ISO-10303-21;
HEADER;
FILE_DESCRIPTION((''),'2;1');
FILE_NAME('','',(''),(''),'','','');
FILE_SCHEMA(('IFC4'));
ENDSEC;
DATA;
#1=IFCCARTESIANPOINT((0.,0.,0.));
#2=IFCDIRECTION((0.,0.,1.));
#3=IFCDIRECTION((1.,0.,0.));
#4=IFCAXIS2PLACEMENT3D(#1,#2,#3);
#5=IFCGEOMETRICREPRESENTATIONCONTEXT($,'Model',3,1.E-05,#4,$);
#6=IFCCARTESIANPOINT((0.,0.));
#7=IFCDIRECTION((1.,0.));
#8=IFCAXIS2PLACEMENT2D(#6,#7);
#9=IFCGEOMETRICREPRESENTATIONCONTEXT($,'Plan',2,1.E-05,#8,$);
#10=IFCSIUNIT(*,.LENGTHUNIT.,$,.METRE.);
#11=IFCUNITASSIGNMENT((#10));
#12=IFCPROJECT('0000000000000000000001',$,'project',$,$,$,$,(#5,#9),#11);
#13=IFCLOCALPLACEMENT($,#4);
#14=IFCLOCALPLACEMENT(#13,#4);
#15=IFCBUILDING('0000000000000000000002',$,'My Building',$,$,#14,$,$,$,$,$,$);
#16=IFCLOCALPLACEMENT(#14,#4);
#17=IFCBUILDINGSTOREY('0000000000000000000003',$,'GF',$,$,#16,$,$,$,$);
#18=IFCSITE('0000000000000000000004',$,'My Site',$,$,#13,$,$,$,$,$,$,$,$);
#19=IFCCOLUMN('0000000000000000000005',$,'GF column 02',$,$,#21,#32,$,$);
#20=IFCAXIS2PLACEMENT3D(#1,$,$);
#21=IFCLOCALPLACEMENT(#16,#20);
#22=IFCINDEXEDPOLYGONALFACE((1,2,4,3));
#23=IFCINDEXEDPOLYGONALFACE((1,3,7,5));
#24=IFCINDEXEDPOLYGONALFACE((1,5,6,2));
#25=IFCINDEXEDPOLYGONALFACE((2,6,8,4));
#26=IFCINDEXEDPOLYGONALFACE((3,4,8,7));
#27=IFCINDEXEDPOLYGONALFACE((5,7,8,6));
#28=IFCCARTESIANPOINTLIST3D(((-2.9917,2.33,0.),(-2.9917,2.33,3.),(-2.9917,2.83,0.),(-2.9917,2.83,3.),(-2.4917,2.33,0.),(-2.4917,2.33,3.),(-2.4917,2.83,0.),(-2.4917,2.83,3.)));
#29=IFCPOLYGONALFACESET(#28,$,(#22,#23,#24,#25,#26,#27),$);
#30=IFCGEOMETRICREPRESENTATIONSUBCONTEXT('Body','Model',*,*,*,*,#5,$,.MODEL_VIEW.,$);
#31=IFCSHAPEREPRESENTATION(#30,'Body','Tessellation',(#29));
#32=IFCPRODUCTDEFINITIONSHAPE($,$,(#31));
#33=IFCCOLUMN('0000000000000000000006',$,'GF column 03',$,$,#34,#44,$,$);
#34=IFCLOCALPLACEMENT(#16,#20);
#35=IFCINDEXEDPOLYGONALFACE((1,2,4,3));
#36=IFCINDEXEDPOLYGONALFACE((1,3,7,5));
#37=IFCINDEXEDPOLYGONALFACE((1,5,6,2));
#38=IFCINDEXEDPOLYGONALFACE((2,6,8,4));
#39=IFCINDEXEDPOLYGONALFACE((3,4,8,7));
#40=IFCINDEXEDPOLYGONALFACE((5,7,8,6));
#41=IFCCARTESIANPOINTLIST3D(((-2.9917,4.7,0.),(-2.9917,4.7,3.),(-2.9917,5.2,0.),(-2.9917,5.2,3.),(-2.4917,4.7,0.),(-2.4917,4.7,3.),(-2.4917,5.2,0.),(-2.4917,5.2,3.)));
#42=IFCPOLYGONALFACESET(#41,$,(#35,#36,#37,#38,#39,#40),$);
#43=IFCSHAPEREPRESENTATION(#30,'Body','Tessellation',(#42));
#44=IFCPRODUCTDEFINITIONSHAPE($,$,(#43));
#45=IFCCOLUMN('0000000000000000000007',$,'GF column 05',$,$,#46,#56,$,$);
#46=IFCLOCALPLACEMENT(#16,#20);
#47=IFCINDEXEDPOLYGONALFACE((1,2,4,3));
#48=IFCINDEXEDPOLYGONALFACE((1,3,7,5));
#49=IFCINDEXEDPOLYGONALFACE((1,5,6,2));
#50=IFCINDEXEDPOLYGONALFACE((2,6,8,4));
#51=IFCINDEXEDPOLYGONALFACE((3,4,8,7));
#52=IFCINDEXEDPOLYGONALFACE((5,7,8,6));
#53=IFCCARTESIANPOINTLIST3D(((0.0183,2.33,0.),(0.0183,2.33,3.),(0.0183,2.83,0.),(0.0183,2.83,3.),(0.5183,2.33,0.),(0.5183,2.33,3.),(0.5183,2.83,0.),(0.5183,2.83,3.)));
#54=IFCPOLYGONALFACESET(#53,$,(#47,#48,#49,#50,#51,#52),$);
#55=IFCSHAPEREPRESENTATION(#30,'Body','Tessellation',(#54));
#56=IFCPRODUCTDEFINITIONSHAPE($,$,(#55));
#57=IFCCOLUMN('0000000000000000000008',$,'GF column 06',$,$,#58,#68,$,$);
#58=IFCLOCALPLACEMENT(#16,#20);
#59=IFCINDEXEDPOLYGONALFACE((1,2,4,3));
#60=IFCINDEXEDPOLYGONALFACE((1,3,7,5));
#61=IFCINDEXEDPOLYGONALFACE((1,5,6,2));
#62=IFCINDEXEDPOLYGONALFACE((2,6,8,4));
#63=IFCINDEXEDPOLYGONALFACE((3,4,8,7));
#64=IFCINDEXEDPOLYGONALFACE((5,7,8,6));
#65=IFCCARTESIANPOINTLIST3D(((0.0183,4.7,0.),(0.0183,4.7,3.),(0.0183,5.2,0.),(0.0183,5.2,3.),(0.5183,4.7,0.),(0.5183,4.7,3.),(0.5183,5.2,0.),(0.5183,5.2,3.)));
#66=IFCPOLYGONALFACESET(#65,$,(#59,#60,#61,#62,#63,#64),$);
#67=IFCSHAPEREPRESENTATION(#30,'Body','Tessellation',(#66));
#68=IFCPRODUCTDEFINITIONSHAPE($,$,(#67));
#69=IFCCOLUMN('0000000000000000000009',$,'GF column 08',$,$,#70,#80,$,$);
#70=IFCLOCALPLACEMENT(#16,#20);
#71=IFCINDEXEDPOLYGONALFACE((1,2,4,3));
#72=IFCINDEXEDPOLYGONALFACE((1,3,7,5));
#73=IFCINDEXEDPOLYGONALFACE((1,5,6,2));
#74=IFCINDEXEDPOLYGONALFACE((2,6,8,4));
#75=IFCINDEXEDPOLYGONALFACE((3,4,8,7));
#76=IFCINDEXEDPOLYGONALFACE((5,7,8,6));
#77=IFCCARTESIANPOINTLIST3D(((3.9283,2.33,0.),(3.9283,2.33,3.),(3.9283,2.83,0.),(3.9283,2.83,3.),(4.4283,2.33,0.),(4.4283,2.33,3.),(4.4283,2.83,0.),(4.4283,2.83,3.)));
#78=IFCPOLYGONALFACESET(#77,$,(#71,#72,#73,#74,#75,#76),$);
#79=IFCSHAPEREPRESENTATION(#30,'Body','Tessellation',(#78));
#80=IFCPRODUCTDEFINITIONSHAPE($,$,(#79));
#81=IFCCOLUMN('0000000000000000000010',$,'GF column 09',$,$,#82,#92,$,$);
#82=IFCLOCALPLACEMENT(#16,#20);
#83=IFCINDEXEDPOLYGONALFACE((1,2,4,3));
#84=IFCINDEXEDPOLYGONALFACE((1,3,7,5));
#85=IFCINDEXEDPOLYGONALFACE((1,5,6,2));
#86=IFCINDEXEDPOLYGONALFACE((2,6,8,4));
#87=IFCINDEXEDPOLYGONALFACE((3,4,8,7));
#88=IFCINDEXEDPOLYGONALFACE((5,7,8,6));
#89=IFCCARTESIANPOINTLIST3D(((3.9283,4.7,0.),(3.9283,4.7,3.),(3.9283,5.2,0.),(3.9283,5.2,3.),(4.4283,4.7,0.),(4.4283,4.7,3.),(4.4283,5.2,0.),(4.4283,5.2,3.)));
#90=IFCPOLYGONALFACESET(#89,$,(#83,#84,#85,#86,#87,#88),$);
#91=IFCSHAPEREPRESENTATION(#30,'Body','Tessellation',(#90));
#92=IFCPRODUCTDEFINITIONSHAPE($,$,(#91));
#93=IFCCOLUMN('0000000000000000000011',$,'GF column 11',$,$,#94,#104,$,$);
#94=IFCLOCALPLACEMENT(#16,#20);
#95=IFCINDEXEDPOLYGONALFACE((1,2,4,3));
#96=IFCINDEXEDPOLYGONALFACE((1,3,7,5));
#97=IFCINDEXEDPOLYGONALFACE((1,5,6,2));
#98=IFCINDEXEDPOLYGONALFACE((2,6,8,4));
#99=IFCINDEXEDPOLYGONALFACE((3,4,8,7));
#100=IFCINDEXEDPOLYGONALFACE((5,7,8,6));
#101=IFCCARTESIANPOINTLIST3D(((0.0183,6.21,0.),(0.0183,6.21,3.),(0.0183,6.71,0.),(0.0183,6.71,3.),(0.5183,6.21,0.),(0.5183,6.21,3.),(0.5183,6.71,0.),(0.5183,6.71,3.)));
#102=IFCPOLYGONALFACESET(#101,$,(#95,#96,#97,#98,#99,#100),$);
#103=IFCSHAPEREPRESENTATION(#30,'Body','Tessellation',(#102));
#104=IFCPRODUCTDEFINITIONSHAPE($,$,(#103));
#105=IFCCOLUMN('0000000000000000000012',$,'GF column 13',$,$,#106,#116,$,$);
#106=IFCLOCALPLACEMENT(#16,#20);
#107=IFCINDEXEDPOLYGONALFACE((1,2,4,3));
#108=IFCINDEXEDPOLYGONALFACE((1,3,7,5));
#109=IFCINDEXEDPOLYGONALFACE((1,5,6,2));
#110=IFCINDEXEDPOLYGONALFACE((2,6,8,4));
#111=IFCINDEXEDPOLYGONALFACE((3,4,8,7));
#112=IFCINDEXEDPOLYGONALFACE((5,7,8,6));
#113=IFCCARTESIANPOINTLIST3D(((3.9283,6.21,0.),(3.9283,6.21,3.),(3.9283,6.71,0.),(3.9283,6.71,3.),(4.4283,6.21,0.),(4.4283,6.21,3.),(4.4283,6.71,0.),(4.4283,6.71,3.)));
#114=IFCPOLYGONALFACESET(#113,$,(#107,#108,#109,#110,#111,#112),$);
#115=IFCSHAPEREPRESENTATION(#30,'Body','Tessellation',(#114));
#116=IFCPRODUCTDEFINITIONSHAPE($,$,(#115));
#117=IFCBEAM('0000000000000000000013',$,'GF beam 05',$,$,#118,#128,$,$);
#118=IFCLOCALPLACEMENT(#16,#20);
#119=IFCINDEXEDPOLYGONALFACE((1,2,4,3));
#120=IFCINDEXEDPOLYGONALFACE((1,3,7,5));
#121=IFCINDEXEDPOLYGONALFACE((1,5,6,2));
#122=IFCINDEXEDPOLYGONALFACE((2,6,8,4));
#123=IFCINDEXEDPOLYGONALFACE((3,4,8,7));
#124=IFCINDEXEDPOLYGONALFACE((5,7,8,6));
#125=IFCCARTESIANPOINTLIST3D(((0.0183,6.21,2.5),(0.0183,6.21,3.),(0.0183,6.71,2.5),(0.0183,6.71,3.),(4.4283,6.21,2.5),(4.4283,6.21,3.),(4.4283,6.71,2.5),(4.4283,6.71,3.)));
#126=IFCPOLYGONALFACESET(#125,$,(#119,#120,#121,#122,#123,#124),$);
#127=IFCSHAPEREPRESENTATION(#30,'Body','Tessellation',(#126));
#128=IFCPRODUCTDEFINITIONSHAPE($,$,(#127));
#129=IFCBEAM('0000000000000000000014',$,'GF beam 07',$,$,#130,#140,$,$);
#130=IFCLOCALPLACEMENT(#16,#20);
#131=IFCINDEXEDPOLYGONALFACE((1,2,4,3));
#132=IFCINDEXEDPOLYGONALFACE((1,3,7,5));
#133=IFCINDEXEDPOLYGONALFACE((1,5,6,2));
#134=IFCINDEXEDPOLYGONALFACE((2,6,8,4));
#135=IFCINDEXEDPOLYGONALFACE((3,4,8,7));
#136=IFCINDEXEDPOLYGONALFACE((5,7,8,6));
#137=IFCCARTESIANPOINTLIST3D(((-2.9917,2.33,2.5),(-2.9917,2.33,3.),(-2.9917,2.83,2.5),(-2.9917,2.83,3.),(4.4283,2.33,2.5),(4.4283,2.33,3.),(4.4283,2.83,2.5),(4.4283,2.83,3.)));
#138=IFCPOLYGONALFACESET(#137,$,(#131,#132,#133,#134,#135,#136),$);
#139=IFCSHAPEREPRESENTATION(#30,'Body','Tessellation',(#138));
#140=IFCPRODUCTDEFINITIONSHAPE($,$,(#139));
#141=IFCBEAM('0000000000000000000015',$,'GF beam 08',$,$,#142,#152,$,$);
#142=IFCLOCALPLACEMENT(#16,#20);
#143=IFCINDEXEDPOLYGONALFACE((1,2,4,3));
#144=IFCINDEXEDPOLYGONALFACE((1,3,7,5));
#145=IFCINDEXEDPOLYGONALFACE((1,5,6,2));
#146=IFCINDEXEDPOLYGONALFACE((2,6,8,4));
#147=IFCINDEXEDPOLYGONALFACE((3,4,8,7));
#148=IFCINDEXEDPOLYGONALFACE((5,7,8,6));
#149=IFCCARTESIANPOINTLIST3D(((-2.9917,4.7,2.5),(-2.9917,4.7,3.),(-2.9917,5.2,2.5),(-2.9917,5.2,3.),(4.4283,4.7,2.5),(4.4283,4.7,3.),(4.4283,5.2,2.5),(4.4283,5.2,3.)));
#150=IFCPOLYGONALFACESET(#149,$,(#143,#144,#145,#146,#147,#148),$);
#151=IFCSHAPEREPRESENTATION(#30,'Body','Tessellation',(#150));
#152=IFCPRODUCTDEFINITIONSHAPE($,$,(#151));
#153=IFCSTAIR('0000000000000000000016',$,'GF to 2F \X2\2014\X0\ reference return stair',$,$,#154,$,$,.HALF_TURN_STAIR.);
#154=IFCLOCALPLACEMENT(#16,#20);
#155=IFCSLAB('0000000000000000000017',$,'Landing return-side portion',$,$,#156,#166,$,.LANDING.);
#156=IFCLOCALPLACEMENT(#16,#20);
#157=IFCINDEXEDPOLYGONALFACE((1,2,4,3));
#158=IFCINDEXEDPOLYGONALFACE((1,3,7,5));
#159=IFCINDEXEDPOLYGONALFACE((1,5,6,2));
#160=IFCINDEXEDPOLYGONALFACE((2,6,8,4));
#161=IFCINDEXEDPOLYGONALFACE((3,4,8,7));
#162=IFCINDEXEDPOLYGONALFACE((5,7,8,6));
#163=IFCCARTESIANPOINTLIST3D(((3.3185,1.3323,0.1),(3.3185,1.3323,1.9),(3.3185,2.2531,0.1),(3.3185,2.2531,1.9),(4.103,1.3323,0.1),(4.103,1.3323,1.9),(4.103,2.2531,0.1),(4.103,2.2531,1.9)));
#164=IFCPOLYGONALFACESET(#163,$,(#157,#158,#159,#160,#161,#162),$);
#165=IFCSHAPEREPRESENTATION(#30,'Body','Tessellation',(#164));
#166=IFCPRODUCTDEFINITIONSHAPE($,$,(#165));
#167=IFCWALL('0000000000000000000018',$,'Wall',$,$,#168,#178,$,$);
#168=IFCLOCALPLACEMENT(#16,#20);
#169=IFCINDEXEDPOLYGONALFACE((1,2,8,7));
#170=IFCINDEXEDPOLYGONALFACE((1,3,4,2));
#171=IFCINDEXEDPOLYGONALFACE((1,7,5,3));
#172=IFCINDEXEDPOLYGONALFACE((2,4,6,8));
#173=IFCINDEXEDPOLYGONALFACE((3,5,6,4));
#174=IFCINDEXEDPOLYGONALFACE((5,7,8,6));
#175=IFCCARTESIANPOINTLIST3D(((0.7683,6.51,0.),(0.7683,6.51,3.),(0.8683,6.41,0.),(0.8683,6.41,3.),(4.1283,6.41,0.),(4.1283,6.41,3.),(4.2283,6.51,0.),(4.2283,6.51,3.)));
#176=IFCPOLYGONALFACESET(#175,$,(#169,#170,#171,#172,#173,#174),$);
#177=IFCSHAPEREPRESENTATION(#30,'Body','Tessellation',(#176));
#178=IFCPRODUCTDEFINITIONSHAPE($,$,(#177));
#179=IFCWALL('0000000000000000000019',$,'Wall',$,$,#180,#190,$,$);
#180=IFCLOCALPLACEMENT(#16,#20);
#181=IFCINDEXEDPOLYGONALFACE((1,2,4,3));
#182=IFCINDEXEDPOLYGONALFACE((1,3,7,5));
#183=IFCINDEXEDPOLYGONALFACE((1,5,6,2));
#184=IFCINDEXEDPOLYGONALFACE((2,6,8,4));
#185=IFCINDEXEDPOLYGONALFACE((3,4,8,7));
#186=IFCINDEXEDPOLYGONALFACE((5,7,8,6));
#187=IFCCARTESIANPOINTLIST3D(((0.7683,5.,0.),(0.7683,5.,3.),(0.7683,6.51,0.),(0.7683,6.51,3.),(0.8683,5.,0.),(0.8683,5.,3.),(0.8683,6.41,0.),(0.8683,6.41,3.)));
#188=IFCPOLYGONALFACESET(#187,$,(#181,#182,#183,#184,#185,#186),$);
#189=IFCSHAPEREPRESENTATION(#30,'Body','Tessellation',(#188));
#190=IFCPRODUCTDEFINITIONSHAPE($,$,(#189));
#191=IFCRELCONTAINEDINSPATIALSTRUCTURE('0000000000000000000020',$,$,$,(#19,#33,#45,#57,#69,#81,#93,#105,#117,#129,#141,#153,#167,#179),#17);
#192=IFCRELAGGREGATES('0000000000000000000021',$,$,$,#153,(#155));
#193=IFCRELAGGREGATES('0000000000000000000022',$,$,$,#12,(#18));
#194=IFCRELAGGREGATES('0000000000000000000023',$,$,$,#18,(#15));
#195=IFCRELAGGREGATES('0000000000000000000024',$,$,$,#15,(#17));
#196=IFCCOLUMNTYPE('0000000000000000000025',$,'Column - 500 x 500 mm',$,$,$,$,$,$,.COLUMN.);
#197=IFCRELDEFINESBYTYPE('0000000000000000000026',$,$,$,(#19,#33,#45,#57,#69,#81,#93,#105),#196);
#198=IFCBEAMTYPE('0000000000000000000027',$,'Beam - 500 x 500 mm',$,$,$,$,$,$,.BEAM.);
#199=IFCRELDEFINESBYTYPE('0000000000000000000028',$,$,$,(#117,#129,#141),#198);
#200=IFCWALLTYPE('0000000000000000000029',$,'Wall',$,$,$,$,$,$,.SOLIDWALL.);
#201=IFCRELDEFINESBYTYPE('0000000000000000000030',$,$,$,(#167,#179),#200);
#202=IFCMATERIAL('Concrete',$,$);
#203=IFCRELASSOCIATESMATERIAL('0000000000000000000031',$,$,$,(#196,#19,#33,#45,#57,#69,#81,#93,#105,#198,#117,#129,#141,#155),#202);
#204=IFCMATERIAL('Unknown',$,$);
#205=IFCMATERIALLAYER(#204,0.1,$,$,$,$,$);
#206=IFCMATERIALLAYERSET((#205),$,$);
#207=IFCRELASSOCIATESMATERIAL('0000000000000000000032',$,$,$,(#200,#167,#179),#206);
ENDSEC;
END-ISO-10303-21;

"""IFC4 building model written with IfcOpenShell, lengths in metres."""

from ifc_helpers import new_model, si_unit, frame, origin_with_axes, origin_2d_with_axis, place, context, subcontext, project, spatial, line, indexed_curve, rectangle, outline, extrude, material, layer, layer_set, layer_usage, material_profile, profile_set, profile_usage, type_object, element, aggregate, save


model = new_model("IFC4")

# Units and contexts
model_context = context("Model", 3, precision=1e-05, world=origin_with_axes())
plan_context = context("Plan", 2, precision=1e-05, world=origin_2d_with_axis())
body_context_1 = subcontext(model_context, "Body", "Model", "MODEL_VIEW")
ifc_project = project(units=[si_unit("LENGTHUNIT", "METRE")], contexts=[model_context, plan_context])

# Site, building, storey
site_placement = place(None, origin_with_axes())
site = spatial("IfcSite", under=ifc_project, at=site_placement, Name="My Site")
building_placement = place(site_placement, origin_with_axes())
building = spatial("IfcBuilding", under=site, at=building_placement, Name="My Building")
storey_placement = place(building_placement, origin_with_axes())
storey = spatial("IfcBuildingStorey", under=building, at=storey_placement, Name="GF")

# Columns
ifc_material_1 = material(Name="Concrete")
ifc_material_profile_1 = material_profile(ifc_material_1, rectangle(XDim=0.5, YDim=0.5))
ifc_profile_set_1 = profile_set([ifc_material_profile_1])
ifc_profile_usage_1 = profile_usage(ifc_profile_set_1, cardinal=5)
column_type = type_object("IfcColumnType", Name="Column - 500 x 500 mm", PredefinedType="COLUMN", material=ifc_profile_set_1)
column_1_placement = place(storey_placement, frame((-2.7417, 2.58, 0.0), z_axis=(0.0, 0.0, 1.0), x_axis=(1.0, 0.0, 0.0)))
element("IfcColumn", 1, at=column_1_placement, inside=storey, type_object=column_type, material=ifc_profile_usage_1, Name="GF column 02", context=body_context_1, shape_type="SweptSolid", body=[
    extrude(rectangle(XDim=0.5, YDim=0.5), origin_with_axes(), (0.0, 0.0, 1.0), 3.0),
])
ifc_profile_usage_2 = profile_usage(ifc_profile_set_1, cardinal=5)
column_2_placement = place(storey_placement, frame((-2.7417, 4.95, 0.0), z_axis=(0.0, 0.0, 1.0), x_axis=(1.0, 0.0, 0.0)))
element("IfcColumn", 2, at=column_2_placement, inside=storey, type_object=column_type, material=ifc_profile_usage_2, Name="GF column 03", context=body_context_1, shape_type="SweptSolid", body=[
    extrude(rectangle(XDim=0.5, YDim=0.5), origin_with_axes(), (0.0, 0.0, 1.0), 3.0),
])
ifc_profile_usage_3 = profile_usage(ifc_profile_set_1, cardinal=5)
column_3_placement = place(storey_placement, frame((0.2683, 2.58, 0.0), z_axis=(0.0, 0.0, 1.0), x_axis=(1.0, 0.0, 0.0)))
element("IfcColumn", 3, at=column_3_placement, inside=storey, type_object=column_type, material=ifc_profile_usage_3, Name="GF column 05", context=body_context_1, shape_type="SweptSolid", body=[
    extrude(rectangle(XDim=0.5, YDim=0.5), origin_with_axes(), (0.0, 0.0, 1.0), 3.0),
])
ifc_profile_usage_4 = profile_usage(ifc_profile_set_1, cardinal=5)
column_4_placement = place(storey_placement, frame((0.2683, 4.95, 0.0), z_axis=(0.0, 0.0, 1.0), x_axis=(1.0, 0.0, 0.0)))
element("IfcColumn", 4, at=column_4_placement, inside=storey, type_object=column_type, material=ifc_profile_usage_4, Name="GF column 06", context=body_context_1, shape_type="SweptSolid", body=[
    extrude(rectangle(XDim=0.5, YDim=0.5), origin_with_axes(), (0.0, 0.0, 1.0), 3.0),
])
ifc_profile_usage_5 = profile_usage(ifc_profile_set_1, cardinal=5)
column_5_placement = place(storey_placement, frame((4.1783, 2.58, 0.0), z_axis=(0.0, 0.0, 1.0), x_axis=(1.0, 0.0, 0.0)))
element("IfcColumn", 5, at=column_5_placement, inside=storey, type_object=column_type, material=ifc_profile_usage_5, Name="GF column 08", context=body_context_1, shape_type="SweptSolid", body=[
    extrude(rectangle(XDim=0.5, YDim=0.5), origin_with_axes(), (0.0, 0.0, 1.0), 3.0),
])
ifc_profile_usage_6 = profile_usage(ifc_profile_set_1, cardinal=5)
column_6_placement = place(storey_placement, frame((4.1783, 4.95, 0.0), z_axis=(0.0, 0.0, 1.0), x_axis=(1.0, 0.0, 0.0)))
element("IfcColumn", 6, at=column_6_placement, inside=storey, type_object=column_type, material=ifc_profile_usage_6, Name="GF column 09", context=body_context_1, shape_type="SweptSolid", body=[
    extrude(rectangle(XDim=0.5, YDim=0.5), origin_with_axes(), (0.0, 0.0, 1.0), 3.0),
])
ifc_profile_usage_7 = profile_usage(ifc_profile_set_1, cardinal=5)
column_7_placement = place(storey_placement, frame((0.2683, 6.46, 0.0), z_axis=(0.0, 0.0, 1.0), x_axis=(1.0, 0.0, 0.0)))
element("IfcColumn", 7, at=column_7_placement, inside=storey, type_object=column_type, material=ifc_profile_usage_7, Name="GF column 11", context=body_context_1, shape_type="SweptSolid", body=[
    extrude(rectangle(XDim=0.5, YDim=0.5), origin_with_axes(), (0.0, 0.0, 1.0), 3.0),
])
ifc_profile_usage_8 = profile_usage(ifc_profile_set_1, cardinal=5)
column_8_placement = place(storey_placement, frame((4.1783, 6.46, 0.0), z_axis=(0.0, 0.0, 1.0), x_axis=(1.0, 0.0, 0.0)))
element("IfcColumn", 8, at=column_8_placement, inside=storey, type_object=column_type, material=ifc_profile_usage_8, Name="GF column 13", context=body_context_1, shape_type="SweptSolid", body=[
    extrude(rectangle(XDim=0.5, YDim=0.5), origin_with_axes(), (0.0, 0.0, 1.0), 3.0),
])

# Beams
ifc_material_profile_2 = material_profile(ifc_material_1, rectangle(XDim=0.5, YDim=0.5))
ifc_profile_set_2 = profile_set([ifc_material_profile_2])
ifc_profile_usage_9 = profile_usage(ifc_profile_set_2, cardinal=5)
beam_type = type_object("IfcBeamType", Name="Beam - 500 x 500 mm", PredefinedType="BEAM", material=ifc_profile_set_2)
beam_1_placement = place(storey_placement, frame((0.0183, 6.46, 2.75), z_axis=(1.0, 0.0, 0.0), x_axis=(0.0, 0.0, 1.0)))
element("IfcBeam", 9, at=beam_1_placement, inside=storey, type_object=beam_type, material=ifc_profile_usage_9, Name="GF beam 05", context=body_context_1, shape_type="SweptSolid", body=[
    extrude(rectangle(XDim=0.5, YDim=0.5), origin_with_axes(), (0.0, 0.0, 1.0), 4.41),
])
ifc_profile_usage_10 = profile_usage(ifc_profile_set_2, cardinal=5)
beam_2_placement = place(storey_placement, frame((-2.9917, 2.58, 2.75), z_axis=(1.0, 0.0, 0.0), x_axis=(0.0, 0.0, 1.0)))
element("IfcBeam", 10, at=beam_2_placement, inside=storey, type_object=beam_type, material=ifc_profile_usage_10, Name="GF beam 07", context=body_context_1, shape_type="SweptSolid", body=[
    extrude(rectangle(XDim=0.5, YDim=0.5), origin_with_axes(), (0.0, 0.0, 1.0), 7.42),
])
ifc_profile_usage_11 = profile_usage(ifc_profile_set_2, cardinal=5)
beam_3_placement = place(storey_placement, frame((-2.9917, 4.95, 2.75), z_axis=(1.0, 0.0, 0.0), x_axis=(0.0, 0.0, 1.0)))
element("IfcBeam", 11, at=beam_3_placement, inside=storey, type_object=beam_type, material=ifc_profile_usage_11, Name="GF beam 08", context=body_context_1, shape_type="SweptSolid", body=[
    extrude(rectangle(XDim=0.5, YDim=0.5), origin_with_axes(), (0.0, 0.0, 1.0), 7.42),
])

# Stair, slab
stair_placement = place(storey_placement, origin_with_axes())
stair = element("IfcStair", 12, at=stair_placement, inside=storey, Name="GF to 2F — reference return stair", PredefinedType="HALF_TURN_STAIR")
slab_placement = place(stair_placement, frame((0.0, 0.0, 0.1), z_axis=(0.0, 0.0, 1.0), x_axis=(1.0, 0.0, 0.0)))
slab = element("IfcSlab", 13, at=slab_placement, material=ifc_material_1, Name="Landing return-side portion", PredefinedType="LANDING", context=body_context_1, shape_type="SweptSolid", body=[
    extrude(outline(indexed_curve([(3.3185, 1.3323), (4.103, 1.3323), (4.103, 2.2531), (3.3185, 2.2531), (3.3185, 1.3323)])), origin_with_axes(), (0.0, 0.0, 1.0), 1.8),
])
aggregate(stair, [slab])

# Walls
ifc_material_2 = material(Name="Unknown")
ifc_layer = layer(ifc_material_2, 0.1)
ifc_layer_set = layer_set([ifc_layer])
ifc_layer_usage_1 = layer_usage(ifc_layer_set, "AXIS2", "POSITIVE", 0.0)
wall_type = type_object("IfcWallType", Name="Wall", PredefinedType="SOLIDWALL", material=ifc_layer_set)
wall_1_placement = place(storey_placement, frame((4.2283, 6.51, 0.0), z_axis=(0.0, 0.0, 1.0), x_axis=(-1.0, 0.0, 0.0)))
element("IfcWall", 14, at=wall_1_placement, inside=storey, type_object=wall_type, material=ifc_layer_usage_1, Name="Wall", context=body_context_1, shape_type="SweptSolid", body=[
    extrude(outline(indexed_curve([(0.0, 0.0), (0.1, 0.1), (3.36, 0.1), (3.46, 0.0)], segments=[line(1, 2, 3, 4, 1)])), origin_with_axes(), (0.0, 0.0, 1.0), 3.0),
])
ifc_layer_usage_2 = layer_usage(ifc_layer_set, "AXIS2", "POSITIVE", 0.0)
wall_2_placement = place(storey_placement, frame((0.7683, 6.51, 0.0), z_axis=(0.0, 0.0, 1.0), x_axis=(0.0, -1.0, 0.0)))
element("IfcWall", 15, at=wall_2_placement, inside=storey, type_object=wall_type, material=ifc_layer_usage_2, Name="Wall", context=body_context_1, shape_type="SweptSolid", body=[
    extrude(outline(indexed_curve([(0.0, 0.0), (0.1, 0.1), (1.51, 0.1), (1.51, 0.0)], segments=[line(1, 2, 3, 4, 1)])), origin_with_axes(), (0.0, 0.0, 1.0), 3.0),
])

save(model, "model.ifc")
